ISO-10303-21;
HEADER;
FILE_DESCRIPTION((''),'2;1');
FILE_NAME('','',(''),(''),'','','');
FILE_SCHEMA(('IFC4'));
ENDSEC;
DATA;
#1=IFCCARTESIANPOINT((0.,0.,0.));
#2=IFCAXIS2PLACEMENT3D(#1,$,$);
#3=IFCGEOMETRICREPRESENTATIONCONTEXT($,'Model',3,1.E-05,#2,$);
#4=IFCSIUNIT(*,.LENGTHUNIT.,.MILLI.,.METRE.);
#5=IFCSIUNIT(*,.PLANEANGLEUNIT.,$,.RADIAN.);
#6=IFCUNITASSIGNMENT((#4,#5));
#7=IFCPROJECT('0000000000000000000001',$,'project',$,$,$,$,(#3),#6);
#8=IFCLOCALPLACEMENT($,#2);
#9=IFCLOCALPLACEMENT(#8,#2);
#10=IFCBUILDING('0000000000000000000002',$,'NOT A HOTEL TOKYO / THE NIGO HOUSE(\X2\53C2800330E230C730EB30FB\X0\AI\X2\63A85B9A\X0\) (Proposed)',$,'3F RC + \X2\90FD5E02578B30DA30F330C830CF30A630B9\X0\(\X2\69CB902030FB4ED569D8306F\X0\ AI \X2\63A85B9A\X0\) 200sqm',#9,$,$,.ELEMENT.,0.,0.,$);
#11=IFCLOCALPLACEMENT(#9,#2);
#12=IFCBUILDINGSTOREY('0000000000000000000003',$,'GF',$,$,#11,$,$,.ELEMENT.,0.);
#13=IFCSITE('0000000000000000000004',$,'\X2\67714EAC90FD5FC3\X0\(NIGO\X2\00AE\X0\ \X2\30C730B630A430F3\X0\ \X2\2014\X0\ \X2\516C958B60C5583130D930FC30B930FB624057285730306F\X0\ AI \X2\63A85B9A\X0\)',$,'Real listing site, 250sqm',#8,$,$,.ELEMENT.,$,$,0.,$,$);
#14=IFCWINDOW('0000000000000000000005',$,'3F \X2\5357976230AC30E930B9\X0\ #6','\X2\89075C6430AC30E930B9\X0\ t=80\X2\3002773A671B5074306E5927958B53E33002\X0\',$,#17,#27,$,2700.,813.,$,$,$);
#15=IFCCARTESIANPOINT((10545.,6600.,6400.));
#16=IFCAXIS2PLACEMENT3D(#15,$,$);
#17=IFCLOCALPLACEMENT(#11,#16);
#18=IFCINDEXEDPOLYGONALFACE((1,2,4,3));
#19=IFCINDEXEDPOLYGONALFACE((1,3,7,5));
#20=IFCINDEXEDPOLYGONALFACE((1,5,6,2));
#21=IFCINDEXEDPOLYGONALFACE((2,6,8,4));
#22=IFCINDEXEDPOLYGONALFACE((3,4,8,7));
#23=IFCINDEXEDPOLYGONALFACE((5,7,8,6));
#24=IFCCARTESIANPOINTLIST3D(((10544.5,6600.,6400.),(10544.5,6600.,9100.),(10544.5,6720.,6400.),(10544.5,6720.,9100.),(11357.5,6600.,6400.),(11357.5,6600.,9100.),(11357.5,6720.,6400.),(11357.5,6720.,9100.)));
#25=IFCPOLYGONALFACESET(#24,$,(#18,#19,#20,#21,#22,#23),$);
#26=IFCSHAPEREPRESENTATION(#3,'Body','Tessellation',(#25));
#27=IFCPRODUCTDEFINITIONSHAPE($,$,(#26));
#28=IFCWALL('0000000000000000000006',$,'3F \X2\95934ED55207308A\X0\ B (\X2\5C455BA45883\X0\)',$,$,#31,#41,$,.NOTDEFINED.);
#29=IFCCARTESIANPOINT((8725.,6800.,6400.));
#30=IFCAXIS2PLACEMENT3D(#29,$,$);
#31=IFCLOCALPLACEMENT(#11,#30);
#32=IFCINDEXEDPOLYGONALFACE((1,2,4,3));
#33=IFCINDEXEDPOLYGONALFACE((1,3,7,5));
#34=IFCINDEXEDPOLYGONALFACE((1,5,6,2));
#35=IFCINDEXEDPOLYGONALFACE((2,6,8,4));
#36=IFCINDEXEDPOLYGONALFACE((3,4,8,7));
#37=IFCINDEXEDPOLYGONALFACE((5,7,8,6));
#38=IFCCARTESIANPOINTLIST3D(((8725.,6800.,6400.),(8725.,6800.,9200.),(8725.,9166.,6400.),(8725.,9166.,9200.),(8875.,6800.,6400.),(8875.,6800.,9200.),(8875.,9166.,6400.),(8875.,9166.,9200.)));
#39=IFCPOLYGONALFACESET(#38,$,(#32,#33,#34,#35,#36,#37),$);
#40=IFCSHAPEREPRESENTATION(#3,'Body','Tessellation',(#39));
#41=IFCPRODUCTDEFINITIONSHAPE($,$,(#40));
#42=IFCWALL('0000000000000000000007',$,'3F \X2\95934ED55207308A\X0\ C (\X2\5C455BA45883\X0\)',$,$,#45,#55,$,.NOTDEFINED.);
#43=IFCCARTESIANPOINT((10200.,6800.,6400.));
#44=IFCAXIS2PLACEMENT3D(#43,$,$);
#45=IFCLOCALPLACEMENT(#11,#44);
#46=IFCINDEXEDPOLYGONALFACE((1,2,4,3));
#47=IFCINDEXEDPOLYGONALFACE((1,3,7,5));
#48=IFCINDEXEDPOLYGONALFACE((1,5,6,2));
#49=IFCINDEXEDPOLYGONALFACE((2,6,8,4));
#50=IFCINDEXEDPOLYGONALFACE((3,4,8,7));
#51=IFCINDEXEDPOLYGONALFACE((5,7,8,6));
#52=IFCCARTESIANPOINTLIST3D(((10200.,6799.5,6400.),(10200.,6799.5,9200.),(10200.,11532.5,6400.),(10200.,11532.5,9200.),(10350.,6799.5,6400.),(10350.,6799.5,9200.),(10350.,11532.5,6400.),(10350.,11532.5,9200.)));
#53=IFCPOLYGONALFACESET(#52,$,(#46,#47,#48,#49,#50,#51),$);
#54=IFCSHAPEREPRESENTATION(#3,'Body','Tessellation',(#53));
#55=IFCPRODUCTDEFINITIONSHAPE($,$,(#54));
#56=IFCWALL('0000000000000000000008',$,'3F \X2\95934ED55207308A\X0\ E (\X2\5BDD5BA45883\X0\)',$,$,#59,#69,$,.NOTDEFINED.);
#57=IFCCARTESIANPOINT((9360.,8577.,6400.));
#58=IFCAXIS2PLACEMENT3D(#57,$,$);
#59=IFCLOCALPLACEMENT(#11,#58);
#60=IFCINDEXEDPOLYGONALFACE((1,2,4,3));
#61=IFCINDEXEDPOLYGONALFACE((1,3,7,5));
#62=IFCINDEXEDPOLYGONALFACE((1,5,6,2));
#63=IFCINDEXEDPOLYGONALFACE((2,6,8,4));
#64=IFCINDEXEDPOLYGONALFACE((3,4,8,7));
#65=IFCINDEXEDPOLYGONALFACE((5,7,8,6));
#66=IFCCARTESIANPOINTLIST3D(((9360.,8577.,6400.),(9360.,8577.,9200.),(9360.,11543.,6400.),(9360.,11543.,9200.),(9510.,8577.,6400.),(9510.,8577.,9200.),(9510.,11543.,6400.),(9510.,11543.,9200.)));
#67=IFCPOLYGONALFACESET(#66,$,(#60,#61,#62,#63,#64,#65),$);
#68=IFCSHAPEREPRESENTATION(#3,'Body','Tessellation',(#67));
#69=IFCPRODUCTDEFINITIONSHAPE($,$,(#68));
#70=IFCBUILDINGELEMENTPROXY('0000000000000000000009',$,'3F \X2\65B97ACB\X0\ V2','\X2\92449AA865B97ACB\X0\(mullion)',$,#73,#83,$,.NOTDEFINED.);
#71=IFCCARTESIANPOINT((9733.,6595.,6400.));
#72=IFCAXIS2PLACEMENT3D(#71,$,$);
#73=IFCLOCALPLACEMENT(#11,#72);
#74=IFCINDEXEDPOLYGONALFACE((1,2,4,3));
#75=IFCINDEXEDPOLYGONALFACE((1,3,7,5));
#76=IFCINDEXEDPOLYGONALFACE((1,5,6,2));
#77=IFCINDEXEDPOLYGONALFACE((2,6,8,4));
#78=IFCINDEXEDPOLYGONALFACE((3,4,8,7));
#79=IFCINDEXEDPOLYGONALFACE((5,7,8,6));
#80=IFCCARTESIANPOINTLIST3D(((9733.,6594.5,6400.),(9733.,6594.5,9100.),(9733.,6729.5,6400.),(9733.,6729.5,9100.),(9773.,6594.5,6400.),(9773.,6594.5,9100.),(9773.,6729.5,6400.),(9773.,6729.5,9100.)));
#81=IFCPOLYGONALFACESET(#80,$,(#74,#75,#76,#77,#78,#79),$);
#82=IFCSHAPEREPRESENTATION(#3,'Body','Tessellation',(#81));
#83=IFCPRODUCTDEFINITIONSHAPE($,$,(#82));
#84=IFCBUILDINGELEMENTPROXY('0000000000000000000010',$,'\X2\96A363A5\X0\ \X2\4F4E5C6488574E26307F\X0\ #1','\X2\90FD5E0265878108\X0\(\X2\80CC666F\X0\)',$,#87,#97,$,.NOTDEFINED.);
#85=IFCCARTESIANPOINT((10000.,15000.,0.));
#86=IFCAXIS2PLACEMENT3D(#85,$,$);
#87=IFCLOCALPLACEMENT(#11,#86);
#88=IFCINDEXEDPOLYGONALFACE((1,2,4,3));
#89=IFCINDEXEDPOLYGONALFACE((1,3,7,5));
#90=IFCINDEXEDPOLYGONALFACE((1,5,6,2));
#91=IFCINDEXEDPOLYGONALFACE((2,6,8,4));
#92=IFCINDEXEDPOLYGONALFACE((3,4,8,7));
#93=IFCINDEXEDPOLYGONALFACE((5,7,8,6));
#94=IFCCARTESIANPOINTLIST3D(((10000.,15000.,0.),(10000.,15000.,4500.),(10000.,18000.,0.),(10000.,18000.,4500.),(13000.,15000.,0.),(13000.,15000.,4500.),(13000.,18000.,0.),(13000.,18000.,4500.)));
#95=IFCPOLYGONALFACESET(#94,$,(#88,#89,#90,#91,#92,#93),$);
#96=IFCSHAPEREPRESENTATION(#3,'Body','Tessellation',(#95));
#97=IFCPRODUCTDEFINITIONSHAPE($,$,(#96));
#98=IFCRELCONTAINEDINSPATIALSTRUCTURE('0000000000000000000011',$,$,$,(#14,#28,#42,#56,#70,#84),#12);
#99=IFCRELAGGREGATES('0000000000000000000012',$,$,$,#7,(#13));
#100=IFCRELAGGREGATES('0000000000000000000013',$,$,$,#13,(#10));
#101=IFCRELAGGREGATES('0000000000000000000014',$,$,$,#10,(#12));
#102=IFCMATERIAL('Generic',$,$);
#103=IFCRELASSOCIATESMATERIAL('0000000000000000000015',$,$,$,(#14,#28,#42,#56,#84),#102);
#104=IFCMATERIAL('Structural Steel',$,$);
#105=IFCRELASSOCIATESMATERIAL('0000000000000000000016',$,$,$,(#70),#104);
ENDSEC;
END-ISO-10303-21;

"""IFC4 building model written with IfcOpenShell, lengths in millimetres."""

from ifc_helpers import new_model, si_unit, frame, frame_2d, origin, place, context, project, spatial, rectangle, extrude, material, element, save


model = new_model("IFC4")

# Units and contexts
model_context = context("Model", 3, precision=1e-05, world=origin())
ifc_project = project(units=[si_unit("LENGTHUNIT", "METRE", prefix="MILLI"), si_unit("PLANEANGLEUNIT", "RADIAN")], contexts=[model_context])

# Site, building, storey
site_placement = place(None, origin())
site = spatial("IfcSite", under=ifc_project, at=site_placement, Name="東京都心(NIGO® デザイン — 公開情報ベース・所在地は AI 推定)", ObjectType="Real listing site, 250sqm", CompositionType="ELEMENT", RefElevation=0.0)
building_placement = place(site_placement, origin())
building = spatial("IfcBuilding", under=site, at=building_placement, Name="NOT A HOTEL TOKYO / THE NIGO HOUSE(参考モデル・AI推定) (Proposed)", ObjectType="3F RC + 都市型ペントハウス(構造・仕様は AI 推定) 200sqm", CompositionType="ELEMENT", ElevationOfRefHeight=0.0, ElevationOfTerrain=0.0)
storey_placement = place(building_placement, origin())
storey = spatial("IfcBuildingStorey", under=building, at=storey_placement, Name="GF", CompositionType="ELEMENT", Elevation=0.0)

# Shared definitions
ifc_material_1 = material(Name="Generic")

# Window
window_1_placement = place(storey_placement, frame((10545.0, 6600.0, 6400.0)))
element("IfcWindow", 1, at=window_1_placement, inside=storey, material=ifc_material_1, Name="3F 南面ガラス #6", Description="複層ガラス t=80。眺望側の大開口。", OverallHeight=2700.0, OverallWidth=813.0, context=model_context, shape_type="SweptSolid", body=[
    extrude(rectangle(XDim=813.0, YDim=120.0, at=frame_2d((406.0, 60.0))), frame((10545.0, 6600.0, 6400.0)), (0.0, 0.0, 1.0), 2700.0),
])

# Walls
wall_1_placement = place(storey_placement, frame((8725.0, 6800.0, 6400.0)))
element("IfcWall", 2, at=wall_1_placement, inside=storey, material=ifc_material_1, Name="3F 間仕切り B (居室境)", PredefinedType="NOTDEFINED", context=model_context, shape_type="SweptSolid", body=[
    extrude(rectangle(XDim=150.0, YDim=2366.0, at=frame_2d((75.0, 1183.0))), frame((8725.0, 6800.0, 6400.0)), (0.0, 0.0, 1.0), 2800.0),
])
wall_2_placement = place(storey_placement, frame((10200.0, 6800.0, 6400.0)))
element("IfcWall", 3, at=wall_2_placement, inside=storey, material=ifc_material_1, Name="3F 間仕切り C (居室境)", PredefinedType="NOTDEFINED", context=model_context, shape_type="SweptSolid", body=[
    extrude(rectangle(XDim=150.0, YDim=4733.0, at=frame_2d((75.0, 2366.0))), frame((10200.0, 6800.0, 6400.0)), (0.0, 0.0, 1.0), 2800.0),
])
wall_3_placement = place(storey_placement, frame((9360.0, 8577.0, 6400.0)))
element("IfcWall", 4, at=wall_3_placement, inside=storey, material=ifc_material_1, Name="3F 間仕切り E (寝室境)", PredefinedType="NOTDEFINED", context=model_context, shape_type="SweptSolid", body=[
    extrude(rectangle(XDim=150.0, YDim=2966.0, at=frame_2d((75.0, 1483.0))), frame((9360.0, 8577.0, 6400.0)), (0.0, 0.0, 1.0), 2800.0),
])

# Building element proxies
ifc_material_2 = material(Name="Structural Steel")
proxy_1_placement = place(storey_placement, frame((9733.0, 6595.0, 6400.0)))
element("IfcBuildingElementProxy", 5, at=proxy_1_placement, inside=storey, material=ifc_material_2, Name="3F 方立 V2", Description="鉄骨方立(mullion)", PredefinedType="NOTDEFINED", context=model_context, shape_type="SweptSolid", body=[
    extrude(rectangle(XDim=40.0, YDim=135.0, at=frame_2d((20.0, 67.0))), frame((9733.0, 6595.0, 6400.0)), (0.0, 0.0, 1.0), 2700.0),
])
proxy_2_placement = place(storey_placement, frame((10000.0, 15000.0, 0.0)))
element("IfcBuildingElementProxy", 6, at=proxy_2_placement, inside=storey, material=ifc_material_1, Name="隣接 低層街並み #1", Description="都市文脈(背景)", PredefinedType="NOTDEFINED", context=model_context, shape_type="SweptSolid", body=[
    extrude(rectangle(XDim=3000.0, YDim=3000.0, at=frame_2d((1500.0, 1500.0))), frame((10000.0, 15000.0, 0.0)), (0.0, 0.0, 1.0), 4500.0),
])

save(model, "model.ifc")
